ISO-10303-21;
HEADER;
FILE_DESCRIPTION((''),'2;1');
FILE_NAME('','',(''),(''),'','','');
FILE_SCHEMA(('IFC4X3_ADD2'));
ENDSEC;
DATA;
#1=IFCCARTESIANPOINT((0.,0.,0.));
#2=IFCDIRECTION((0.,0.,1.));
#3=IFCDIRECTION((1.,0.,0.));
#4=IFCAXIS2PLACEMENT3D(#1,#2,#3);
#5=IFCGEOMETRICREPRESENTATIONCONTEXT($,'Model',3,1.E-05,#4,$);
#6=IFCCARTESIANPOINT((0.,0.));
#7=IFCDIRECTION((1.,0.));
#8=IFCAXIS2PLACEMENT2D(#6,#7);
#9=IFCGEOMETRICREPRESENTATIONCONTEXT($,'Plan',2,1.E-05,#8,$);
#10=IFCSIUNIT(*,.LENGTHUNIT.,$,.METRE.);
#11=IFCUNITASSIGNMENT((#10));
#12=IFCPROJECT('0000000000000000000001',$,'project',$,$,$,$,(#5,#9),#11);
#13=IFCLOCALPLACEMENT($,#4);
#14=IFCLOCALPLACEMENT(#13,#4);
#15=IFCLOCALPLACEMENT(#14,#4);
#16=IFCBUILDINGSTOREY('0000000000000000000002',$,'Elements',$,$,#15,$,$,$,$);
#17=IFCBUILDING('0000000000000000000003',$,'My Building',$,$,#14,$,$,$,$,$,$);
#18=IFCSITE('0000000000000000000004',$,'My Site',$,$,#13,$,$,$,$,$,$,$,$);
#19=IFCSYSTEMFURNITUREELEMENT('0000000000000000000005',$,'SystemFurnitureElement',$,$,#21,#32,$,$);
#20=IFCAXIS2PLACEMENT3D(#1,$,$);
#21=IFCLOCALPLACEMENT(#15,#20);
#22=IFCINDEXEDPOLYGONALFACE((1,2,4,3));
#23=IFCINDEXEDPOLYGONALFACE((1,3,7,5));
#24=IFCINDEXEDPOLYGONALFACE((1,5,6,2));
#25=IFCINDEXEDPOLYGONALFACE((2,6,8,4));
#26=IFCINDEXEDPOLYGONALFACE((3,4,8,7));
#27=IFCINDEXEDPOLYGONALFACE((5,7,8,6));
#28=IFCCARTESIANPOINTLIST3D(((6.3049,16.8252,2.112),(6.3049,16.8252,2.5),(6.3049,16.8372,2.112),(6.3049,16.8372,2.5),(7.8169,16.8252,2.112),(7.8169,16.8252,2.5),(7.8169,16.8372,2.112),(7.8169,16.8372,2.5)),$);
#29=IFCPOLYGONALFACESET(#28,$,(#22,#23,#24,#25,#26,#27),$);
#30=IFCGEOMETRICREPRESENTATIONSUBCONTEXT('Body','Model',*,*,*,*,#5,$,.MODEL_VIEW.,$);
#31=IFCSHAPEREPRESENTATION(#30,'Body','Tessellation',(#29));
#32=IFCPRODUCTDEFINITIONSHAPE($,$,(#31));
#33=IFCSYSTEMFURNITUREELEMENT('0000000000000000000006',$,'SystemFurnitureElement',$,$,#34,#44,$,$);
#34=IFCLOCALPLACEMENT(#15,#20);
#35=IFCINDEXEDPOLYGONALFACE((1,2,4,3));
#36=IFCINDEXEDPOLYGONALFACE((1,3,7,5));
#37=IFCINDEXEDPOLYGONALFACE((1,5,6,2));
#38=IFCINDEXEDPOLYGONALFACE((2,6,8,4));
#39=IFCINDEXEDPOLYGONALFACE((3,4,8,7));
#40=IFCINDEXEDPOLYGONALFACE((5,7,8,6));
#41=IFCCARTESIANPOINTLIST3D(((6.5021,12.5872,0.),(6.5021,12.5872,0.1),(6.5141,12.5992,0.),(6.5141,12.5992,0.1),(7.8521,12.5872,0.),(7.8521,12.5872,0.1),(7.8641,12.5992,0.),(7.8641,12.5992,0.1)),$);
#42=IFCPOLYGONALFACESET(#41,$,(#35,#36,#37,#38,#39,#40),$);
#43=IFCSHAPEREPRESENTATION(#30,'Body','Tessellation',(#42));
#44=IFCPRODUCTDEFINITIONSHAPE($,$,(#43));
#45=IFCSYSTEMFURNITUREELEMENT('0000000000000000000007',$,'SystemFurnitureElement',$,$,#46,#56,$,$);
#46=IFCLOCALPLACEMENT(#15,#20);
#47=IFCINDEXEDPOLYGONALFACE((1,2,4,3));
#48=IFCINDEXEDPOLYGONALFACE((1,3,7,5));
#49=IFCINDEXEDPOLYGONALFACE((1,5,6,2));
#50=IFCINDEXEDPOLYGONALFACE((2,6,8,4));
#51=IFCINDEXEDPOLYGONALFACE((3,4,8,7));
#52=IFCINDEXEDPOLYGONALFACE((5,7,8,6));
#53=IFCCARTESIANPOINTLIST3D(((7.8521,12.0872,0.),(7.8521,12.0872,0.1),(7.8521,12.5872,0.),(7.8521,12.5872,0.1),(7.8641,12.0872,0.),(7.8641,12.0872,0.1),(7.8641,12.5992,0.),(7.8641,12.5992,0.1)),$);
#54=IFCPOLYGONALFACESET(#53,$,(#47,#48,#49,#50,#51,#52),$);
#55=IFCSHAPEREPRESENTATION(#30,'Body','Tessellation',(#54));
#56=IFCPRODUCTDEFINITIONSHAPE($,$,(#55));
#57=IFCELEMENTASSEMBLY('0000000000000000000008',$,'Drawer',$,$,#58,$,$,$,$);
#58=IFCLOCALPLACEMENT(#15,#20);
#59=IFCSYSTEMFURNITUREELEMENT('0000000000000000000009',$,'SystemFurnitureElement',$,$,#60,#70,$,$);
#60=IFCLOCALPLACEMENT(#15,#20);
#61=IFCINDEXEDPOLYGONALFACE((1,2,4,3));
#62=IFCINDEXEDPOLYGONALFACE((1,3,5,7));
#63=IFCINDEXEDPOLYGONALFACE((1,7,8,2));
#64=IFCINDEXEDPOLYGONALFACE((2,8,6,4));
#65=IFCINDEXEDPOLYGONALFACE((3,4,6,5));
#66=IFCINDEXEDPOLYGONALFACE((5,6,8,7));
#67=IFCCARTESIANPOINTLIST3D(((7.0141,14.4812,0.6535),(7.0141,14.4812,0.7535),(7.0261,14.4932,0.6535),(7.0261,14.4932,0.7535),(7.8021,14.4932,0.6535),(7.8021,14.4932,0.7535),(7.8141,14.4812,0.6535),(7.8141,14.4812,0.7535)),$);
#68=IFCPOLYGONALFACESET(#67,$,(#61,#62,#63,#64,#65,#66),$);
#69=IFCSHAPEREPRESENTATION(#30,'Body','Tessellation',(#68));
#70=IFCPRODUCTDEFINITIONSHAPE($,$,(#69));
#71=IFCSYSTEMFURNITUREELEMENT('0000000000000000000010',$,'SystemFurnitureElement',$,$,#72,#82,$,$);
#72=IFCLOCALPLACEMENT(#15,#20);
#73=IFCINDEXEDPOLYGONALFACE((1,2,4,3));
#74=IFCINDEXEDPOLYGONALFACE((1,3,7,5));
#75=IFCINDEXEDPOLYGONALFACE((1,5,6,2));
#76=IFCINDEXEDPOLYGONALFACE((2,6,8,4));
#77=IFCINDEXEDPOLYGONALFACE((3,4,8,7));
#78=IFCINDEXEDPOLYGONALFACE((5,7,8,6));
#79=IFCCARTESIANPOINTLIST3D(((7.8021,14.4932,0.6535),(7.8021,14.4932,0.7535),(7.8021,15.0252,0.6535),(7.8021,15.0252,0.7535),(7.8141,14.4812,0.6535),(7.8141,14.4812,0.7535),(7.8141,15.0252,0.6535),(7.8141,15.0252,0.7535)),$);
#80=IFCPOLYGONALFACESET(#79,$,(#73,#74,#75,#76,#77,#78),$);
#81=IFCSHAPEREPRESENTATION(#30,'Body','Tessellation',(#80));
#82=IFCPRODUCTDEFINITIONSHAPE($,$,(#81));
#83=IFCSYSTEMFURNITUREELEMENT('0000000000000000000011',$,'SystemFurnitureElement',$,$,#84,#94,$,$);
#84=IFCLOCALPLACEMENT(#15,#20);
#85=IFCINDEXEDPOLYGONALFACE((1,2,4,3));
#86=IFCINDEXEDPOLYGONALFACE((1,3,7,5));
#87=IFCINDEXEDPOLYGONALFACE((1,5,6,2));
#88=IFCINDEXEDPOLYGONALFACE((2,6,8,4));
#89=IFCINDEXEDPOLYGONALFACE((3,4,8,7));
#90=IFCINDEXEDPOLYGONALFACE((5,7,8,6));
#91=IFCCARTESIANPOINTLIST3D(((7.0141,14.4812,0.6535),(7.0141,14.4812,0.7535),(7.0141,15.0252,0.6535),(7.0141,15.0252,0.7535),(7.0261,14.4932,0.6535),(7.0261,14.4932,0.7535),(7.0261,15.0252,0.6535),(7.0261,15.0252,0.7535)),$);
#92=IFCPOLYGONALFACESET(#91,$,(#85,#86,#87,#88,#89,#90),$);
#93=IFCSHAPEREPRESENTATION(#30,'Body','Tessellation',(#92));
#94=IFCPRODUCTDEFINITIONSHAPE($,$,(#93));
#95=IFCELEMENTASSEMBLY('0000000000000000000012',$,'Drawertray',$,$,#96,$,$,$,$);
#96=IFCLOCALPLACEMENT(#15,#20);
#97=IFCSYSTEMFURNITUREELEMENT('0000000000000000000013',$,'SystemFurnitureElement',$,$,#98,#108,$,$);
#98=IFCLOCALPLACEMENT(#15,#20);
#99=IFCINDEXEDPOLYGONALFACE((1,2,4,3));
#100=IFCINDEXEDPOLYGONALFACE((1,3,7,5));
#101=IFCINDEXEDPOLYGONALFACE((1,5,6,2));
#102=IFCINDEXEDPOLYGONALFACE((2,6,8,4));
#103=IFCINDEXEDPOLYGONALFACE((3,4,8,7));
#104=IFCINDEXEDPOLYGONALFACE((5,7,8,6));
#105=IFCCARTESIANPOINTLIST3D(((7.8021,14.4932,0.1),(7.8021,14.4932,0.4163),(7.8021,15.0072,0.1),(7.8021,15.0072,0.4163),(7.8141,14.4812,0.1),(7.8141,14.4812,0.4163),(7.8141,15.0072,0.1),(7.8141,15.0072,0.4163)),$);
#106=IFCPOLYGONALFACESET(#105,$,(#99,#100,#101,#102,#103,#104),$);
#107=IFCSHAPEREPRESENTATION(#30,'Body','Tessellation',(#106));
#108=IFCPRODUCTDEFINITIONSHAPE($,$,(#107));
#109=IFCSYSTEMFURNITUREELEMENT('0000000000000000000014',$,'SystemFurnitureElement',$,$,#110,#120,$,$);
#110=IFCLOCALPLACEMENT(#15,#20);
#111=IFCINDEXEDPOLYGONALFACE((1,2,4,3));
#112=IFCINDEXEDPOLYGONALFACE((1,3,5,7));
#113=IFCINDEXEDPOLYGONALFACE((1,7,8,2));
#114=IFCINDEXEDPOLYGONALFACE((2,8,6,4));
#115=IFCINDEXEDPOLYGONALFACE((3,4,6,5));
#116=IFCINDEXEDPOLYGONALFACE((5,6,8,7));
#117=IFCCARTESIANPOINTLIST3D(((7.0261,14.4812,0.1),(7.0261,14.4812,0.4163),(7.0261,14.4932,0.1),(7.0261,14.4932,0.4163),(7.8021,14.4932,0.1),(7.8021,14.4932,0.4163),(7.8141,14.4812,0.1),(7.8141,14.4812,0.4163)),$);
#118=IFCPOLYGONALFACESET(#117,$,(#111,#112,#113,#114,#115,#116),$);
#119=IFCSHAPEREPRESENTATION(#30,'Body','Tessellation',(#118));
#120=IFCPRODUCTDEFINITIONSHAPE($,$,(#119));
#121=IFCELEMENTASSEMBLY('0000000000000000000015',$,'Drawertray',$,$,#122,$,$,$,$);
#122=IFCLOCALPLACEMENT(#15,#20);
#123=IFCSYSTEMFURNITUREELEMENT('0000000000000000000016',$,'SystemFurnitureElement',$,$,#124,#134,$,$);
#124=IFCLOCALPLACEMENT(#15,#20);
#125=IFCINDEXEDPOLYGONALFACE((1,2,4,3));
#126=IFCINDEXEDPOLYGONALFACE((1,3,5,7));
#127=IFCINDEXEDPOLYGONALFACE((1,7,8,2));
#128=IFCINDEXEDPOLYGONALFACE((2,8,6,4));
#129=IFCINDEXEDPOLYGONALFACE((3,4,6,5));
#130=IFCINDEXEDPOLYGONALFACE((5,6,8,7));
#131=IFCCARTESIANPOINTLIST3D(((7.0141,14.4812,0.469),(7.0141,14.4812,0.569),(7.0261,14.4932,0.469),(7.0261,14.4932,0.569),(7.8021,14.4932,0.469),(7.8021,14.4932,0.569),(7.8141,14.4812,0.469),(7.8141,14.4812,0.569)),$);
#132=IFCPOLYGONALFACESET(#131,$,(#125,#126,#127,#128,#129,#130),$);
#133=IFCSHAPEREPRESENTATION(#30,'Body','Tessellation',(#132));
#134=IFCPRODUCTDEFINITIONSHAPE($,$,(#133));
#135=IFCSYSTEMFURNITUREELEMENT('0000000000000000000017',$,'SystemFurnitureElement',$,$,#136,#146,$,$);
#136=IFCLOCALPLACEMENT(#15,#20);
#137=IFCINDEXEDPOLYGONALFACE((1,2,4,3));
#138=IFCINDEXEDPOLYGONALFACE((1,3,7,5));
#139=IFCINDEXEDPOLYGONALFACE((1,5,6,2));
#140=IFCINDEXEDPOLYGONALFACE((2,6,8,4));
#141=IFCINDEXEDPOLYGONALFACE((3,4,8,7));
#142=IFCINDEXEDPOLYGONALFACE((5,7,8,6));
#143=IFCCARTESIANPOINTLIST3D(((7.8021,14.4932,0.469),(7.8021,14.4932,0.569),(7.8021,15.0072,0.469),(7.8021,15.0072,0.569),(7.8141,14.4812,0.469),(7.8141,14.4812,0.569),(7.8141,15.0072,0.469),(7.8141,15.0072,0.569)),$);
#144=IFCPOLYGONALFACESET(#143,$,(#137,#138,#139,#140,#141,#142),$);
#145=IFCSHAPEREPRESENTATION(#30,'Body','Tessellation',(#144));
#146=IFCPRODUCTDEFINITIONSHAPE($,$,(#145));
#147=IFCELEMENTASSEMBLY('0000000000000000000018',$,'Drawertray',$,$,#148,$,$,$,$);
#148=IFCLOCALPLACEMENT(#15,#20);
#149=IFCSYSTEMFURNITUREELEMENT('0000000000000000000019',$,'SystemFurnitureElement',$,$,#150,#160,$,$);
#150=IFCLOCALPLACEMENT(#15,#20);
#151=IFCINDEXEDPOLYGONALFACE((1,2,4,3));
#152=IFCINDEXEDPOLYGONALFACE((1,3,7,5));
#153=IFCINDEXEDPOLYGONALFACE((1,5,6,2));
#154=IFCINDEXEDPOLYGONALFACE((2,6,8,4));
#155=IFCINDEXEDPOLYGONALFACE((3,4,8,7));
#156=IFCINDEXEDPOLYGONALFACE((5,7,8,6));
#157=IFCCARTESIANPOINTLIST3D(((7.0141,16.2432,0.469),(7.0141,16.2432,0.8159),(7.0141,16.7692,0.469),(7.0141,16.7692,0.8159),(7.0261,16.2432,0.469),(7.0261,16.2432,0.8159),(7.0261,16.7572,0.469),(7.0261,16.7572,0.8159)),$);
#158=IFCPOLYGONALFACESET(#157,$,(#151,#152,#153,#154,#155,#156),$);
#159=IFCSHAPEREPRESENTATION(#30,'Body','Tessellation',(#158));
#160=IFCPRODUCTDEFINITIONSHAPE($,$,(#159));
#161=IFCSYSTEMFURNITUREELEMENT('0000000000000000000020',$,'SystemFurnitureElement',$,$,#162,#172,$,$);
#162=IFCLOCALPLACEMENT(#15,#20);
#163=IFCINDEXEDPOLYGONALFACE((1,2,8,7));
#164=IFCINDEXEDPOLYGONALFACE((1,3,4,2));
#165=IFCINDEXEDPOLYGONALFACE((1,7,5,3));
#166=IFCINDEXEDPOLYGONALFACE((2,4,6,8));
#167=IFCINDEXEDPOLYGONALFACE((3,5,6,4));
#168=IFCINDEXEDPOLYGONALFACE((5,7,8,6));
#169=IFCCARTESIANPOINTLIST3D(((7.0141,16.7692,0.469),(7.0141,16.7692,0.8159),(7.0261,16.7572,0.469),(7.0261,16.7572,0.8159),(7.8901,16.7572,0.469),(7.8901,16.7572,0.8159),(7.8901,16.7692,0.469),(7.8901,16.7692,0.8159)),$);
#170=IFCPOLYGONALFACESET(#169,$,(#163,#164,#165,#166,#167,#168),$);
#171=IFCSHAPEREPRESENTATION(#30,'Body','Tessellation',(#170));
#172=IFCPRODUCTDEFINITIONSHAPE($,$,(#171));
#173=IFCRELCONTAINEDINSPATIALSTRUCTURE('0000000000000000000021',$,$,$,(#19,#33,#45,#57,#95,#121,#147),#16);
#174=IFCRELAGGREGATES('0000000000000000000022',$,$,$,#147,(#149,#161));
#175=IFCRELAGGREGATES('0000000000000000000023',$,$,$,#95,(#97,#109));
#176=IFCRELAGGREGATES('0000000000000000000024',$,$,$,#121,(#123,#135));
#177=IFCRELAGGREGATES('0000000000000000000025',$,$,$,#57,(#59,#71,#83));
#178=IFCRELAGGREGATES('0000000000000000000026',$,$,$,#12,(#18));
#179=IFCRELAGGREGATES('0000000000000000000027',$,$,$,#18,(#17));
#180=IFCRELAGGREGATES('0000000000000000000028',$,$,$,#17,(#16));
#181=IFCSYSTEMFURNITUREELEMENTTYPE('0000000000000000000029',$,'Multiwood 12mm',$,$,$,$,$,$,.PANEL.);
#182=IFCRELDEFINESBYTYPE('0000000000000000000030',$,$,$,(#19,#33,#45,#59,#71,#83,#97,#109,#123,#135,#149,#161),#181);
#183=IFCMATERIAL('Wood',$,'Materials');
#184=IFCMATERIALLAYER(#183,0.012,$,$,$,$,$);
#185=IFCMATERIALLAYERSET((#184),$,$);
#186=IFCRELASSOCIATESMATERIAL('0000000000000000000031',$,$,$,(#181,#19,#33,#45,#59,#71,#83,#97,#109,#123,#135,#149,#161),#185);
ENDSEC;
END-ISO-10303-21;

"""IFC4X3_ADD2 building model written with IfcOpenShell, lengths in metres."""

from ifc_helpers import new_model, si_unit, frame, origin_with_axes, origin_2d_with_axis, place, context, subcontext, project, spatial, line, indexed_curve, outline, extrude, material, layer, layer_set, layer_usage, type_object, element, aggregate, save


model = new_model("IFC4X3_ADD2")

# Units and contexts
model_context = context("Model", 3, precision=1e-05, world=origin_with_axes())
plan_context = context("Plan", 2, precision=1e-05, world=origin_2d_with_axis())
body_context = subcontext(model_context, "Body", "Model", "MODEL_VIEW")
ifc_project = project(units=[si_unit("LENGTHUNIT", "METRE")], contexts=[model_context, plan_context])

# Site, building, storey
site_placement = place(None, origin_with_axes())
site = spatial("IfcSite", under=ifc_project, at=site_placement, Name="My Site")
building_placement = place(site_placement, origin_with_axes())
building = spatial("IfcBuilding", under=site, at=building_placement, Name="My Building")
storey_placement = place(building_placement, origin_with_axes())
storey = spatial("IfcBuildingStorey", under=building, at=storey_placement, Name="Elements")

# System furniture elements
ifc_material_1 = material(Name="Wood", Category="Materials")
ifc_layer_1 = layer(ifc_material_1, 0.012)
ifc_layer_set_1 = layer_set([ifc_layer_1])
system_furniture_element_type_1 = type_object("IfcSystemFurnitureElementType", Name="Multiwood 12mm", PredefinedType="PANEL", material=ifc_layer_set_1)
ifc_layer_usage_1 = layer_usage(ifc_layer_set_1, "AXIS2", "POSITIVE", 0.0)
system_furniture_element_1_placement = place(storey_placement, frame((7.8169, 16.8372, 2.112), z_axis=(0.0, 0.0, 1.0), x_axis=(-1.0, 0.000001, 0.0)))
element("IfcSystemFurnitureElement", 1, at=system_furniture_element_1_placement, inside=storey, type_object=system_furniture_element_type_1, material=ifc_layer_usage_1, Name="SystemFurnitureElement", context=body_context, shape_type="SweptSolid", body=[
    extrude(outline(indexed_curve([(0.0, 0.0), (0.0, 0.012), (1.512, 0.012), (1.512, 0.0)], segments=[line(1, 2, 3, 4, 1)])), origin_with_axes(), (0.0, 0.0, 1.0), 0.388),
])
ifc_layer_usage_2 = layer_usage(ifc_layer_set_1, "AXIS2", "POSITIVE", 0.0)
system_furniture_element_2_placement = place(storey_placement, frame((7.8521, 12.5992, 0.0), z_axis=(0.0, 0.0, 1.0), x_axis=(-1.0, 0.0, 0.0)))
element("IfcSystemFurnitureElement", 2, at=system_furniture_element_2_placement, inside=storey, type_object=system_furniture_element_type_1, material=ifc_layer_usage_2, Name="SystemFurnitureElement", context=body_context, shape_type="SweptSolid", body=[
    extrude(outline(indexed_curve([(-0.012, 0.0), (0.0, 0.012), (1.35, 0.012), (1.338, 0.0)], segments=[line(1, 2, 3, 4, 1)])), origin_with_axes(), (0.0, 0.0, 1.0), 0.1),
])
ifc_layer_usage_3 = layer_usage(ifc_layer_set_1, "AXIS2", "POSITIVE", 0.0)
system_furniture_element_3_placement = place(storey_placement, frame((7.8521, 12.5992, 0.0), z_axis=(0.0, 0.0, 1.0), x_axis=(0.0, -1.0, 0.0)))
element("IfcSystemFurnitureElement", 3, at=system_furniture_element_3_placement, inside=storey, type_object=system_furniture_element_type_1, material=ifc_layer_usage_3, Name="SystemFurnitureElement", context=body_context, shape_type="SweptSolid", body=[
    extrude(outline(indexed_curve([(0.012, 0.0), (0.0, 0.012), (0.512, 0.012), (0.512, 0.0)], segments=[line(1, 2, 3, 4, 1)])), origin_with_axes(), (0.0, 0.0, 1.0), 0.1),
])

# Element assemblies, system furniture elements
assembly_1_placement = place(storey_placement, frame((7.8141, 15.0252, 0.6535), z_axis=(0.0, 0.0, 1.0), x_axis=(1.0, 0.0, 0.0)))
assembly_1 = element("IfcElementAssembly", 4, at=assembly_1_placement, inside=storey, Name="Drawer")
ifc_layer_usage_4 = layer_usage(ifc_layer_set_1, "AXIS2", "POSITIVE", 0.0)
system_furniture_element_4_placement = place(assembly_1_placement, frame((0.0, -0.532, 0.0), z_axis=(0.0, 0.0, 1.0), x_axis=(-1.0, 0.0, 0.0)))
system_furniture_element_4 = element("IfcSystemFurnitureElement", 5, at=system_furniture_element_4_placement, type_object=system_furniture_element_type_1, material=ifc_layer_usage_4, Name="SystemFurnitureElement", context=body_context, shape_type="SweptSolid", body=[
    extrude(outline(indexed_curve([(0.012, 0.0), (0.0, 0.012), (0.8, 0.012), (0.788, 0.0)], segments=[line(1, 2, 3, 4, 1)])), origin_with_axes(), (0.0, 0.0, 1.0), 0.1),
])
ifc_layer_usage_5 = layer_usage(ifc_layer_set_1, "AXIS2", "POSITIVE", 0.0)
system_furniture_element_5_placement = place(assembly_1_placement, frame((0.0, -0.532, 0.0), z_axis=(0.0, 0.0, 1.0), x_axis=(0.000001, 1.0, 0.0)))
system_furniture_element_5 = element("IfcSystemFurnitureElement", 6, at=system_furniture_element_5_placement, type_object=system_furniture_element_type_1, material=ifc_layer_usage_5, Name="SystemFurnitureElement", context=body_context, shape_type="SweptSolid", body=[
    extrude(outline(indexed_curve([(-0.012, 0.0), (0.0, 0.012), (0.532, 0.012), (0.532, 0.0)], segments=[line(1, 2, 3, 4, 1)])), origin_with_axes(), (0.0, 0.0, 1.0), 0.1),
])
ifc_layer_usage_6 = layer_usage(ifc_layer_set_1, "AXIS2", "POSITIVE", 0.0)
system_furniture_element_6_placement = place(assembly_1_placement, frame((-0.788, -0.532, 0.0), z_axis=(0.0, 0.0, 1.0), x_axis=(0.000001, 1.0, 0.0)))
system_furniture_element_6 = element("IfcSystemFurnitureElement", 7, at=system_furniture_element_6_placement, type_object=system_furniture_element_type_1, material=ifc_layer_usage_6, Name="SystemFurnitureElement", context=body_context, shape_type="SweptSolid", body=[
    extrude(outline(indexed_curve([(0.0, 0.0), (-0.012, 0.012), (0.532, 0.012), (0.532, 0.0)], segments=[line(1, 2, 3, 4, 1)])), origin_with_axes(), (0.0, 0.0, 1.0), 0.1),
])
assembly_2_placement = place(storey_placement, frame((7.8141, 15.0252, 0.1), z_axis=(0.0, 0.0, 1.0), x_axis=(1.0, 0.0, 0.0)))
assembly_2 = element("IfcElementAssembly", 8, at=assembly_2_placement, inside=storey, Name="Drawertray")
ifc_layer_usage_7 = layer_usage(ifc_layer_set_1, "AXIS2", "POSITIVE", 0.0)
system_furniture_element_7_placement = place(assembly_2_placement, frame((0.0, -0.532, 0.0), z_axis=(0.0, 0.0, 1.0), x_axis=(0.000001, 1.0, 0.0)))
system_furniture_element_7 = element("IfcSystemFurnitureElement", 9, at=system_furniture_element_7_placement, type_object=system_furniture_element_type_1, material=ifc_layer_usage_7, Name="SystemFurnitureElement", context=body_context, shape_type="SweptSolid", body=[
    extrude(outline(indexed_curve([(-0.012, 0.0), (0.0, 0.012), (0.514, 0.012), (0.514, 0.0)], segments=[line(1, 2, 3, 4, 1)])), origin_with_axes(), (0.0, 0.0, 1.0), 0.3163),
])
ifc_layer_usage_8 = layer_usage(ifc_layer_set_1, "AXIS2", "POSITIVE", 0.0)
system_furniture_element_8_placement = place(assembly_2_placement, frame((0.0, -0.532, 0.0), z_axis=(0.0, 0.0, 1.0), x_axis=(-1.0, 0.0, 0.0)))
system_furniture_element_8 = element("IfcSystemFurnitureElement", 10, at=system_furniture_element_8_placement, type_object=system_furniture_element_type_1, material=ifc_layer_usage_8, Name="SystemFurnitureElement", context=body_context, shape_type="SweptSolid", body=[
    extrude(outline(indexed_curve([(0.012, 0.0), (0.0, 0.012), (0.788, 0.012), (0.788, 0.0)], segments=[line(1, 2, 3, 4, 1)])), origin_with_axes(), (0.0, 0.0, 1.0), 0.3163),
])
assembly_3_placement = place(storey_placement, frame((7.8141, 15.0252, 0.469), z_axis=(0.0, 0.0, 1.0), x_axis=(1.0, 0.0, 0.0)))
assembly_3 = element("IfcElementAssembly", 11, at=assembly_3_placement, inside=storey, Name="Drawertray")
ifc_layer_usage_9 = layer_usage(ifc_layer_set_1, "AXIS2", "POSITIVE", 0.0)
system_furniture_element_9_placement = place(assembly_3_placement, frame((0.0, -0.532, 0.0), z_axis=(0.0, 0.0, 1.0), x_axis=(-1.0, 0.0, 0.0)))
system_furniture_element_9 = element("IfcSystemFurnitureElement", 12, at=system_furniture_element_9_placement, type_object=system_furniture_element_type_1, material=ifc_layer_usage_9, Name="SystemFurnitureElement", context=body_context, shape_type="SweptSolid", body=[
    extrude(outline(indexed_curve([(0.012, 0.0), (0.0, 0.012), (0.8, 0.012), (0.788, 0.0)], segments=[line(1, 2, 3, 4, 1)])), origin_with_axes(), (0.0, 0.0, 1.0), 0.1),
])
ifc_layer_usage_10 = layer_usage(ifc_layer_set_1, "AXIS2", "POSITIVE", 0.0)
system_furniture_element_10_placement = place(assembly_3_placement, frame((0.0, -0.532, 0.0), z_axis=(0.0, 0.0, 1.0), x_axis=(0.000001, 1.0, 0.0)))
system_furniture_element_10 = element("IfcSystemFurnitureElement", 13, at=system_furniture_element_10_placement, type_object=system_furniture_element_type_1, material=ifc_layer_usage_10, Name="SystemFurnitureElement", context=body_context, shape_type="SweptSolid", body=[
    extrude(outline(indexed_curve([(-0.012, 0.0), (0.0, 0.012), (0.514, 0.012), (0.514, 0.0)], segments=[line(1, 2, 3, 4, 1)])), origin_with_axes(), (0.0, 0.0, 1.0), 0.1),
])
assembly_4_placement = place(storey_placement, frame((7.0141, 16.2252, 0.469), z_axis=(0.0, 0.0, 1.0), x_axis=(-1.0, 0.0, 0.0)))
assembly_4 = element("IfcElementAssembly", 14, at=assembly_4_placement, inside=storey, Name="Drawertray")
ifc_layer_usage_11 = layer_usage(ifc_layer_set_1, "AXIS2", "POSITIVE", 0.0)
system_furniture_element_11_placement = place(assembly_4_placement, frame((0.0, -0.532, 0.0), z_axis=(0.0, 0.0, 1.0), x_axis=(0.000001, 1.0, 0.0)))
system_furniture_element_11 = element("IfcSystemFurnitureElement", 15, at=system_furniture_element_11_placement, type_object=system_furniture_element_type_1, material=ifc_layer_usage_11, Name="SystemFurnitureElement", context=body_context, shape_type="SweptSolid", body=[
    extrude(outline(indexed_curve([(-0.012, 0.0), (0.0, 0.012), (0.514, 0.012), (0.514, 0.0)], segments=[line(1, 2, 3, 4, 1)])), origin_with_axes(), (0.0, 0.0, 1.0), 0.3469),
])
ifc_layer_usage_12 = layer_usage(ifc_layer_set_1, "AXIS2", "POSITIVE", 0.0)
system_furniture_element_12_placement = place(assembly_4_placement, frame((0.0, -0.532, 0.0), z_axis=(0.0, 0.0, 1.0), x_axis=(-1.0, 0.0, 0.0)))
system_furniture_element_12 = element("IfcSystemFurnitureElement", 16, at=system_furniture_element_12_placement, type_object=system_furniture_element_type_1, material=ifc_layer_usage_12, Name="SystemFurnitureElement", context=body_context, shape_type="SweptSolid", body=[
    extrude(outline(indexed_curve([(0.012, 0.0), (0.0, 0.012), (0.876, 0.012), (0.876, 0.0)], segments=[line(1, 2, 3, 4, 1)])), origin_with_axes(), (0.0, 0.0, 1.0), 0.3469),
])

aggregate(assembly_4, [system_furniture_element_11, system_furniture_element_12])

aggregate(assembly_2, [system_furniture_element_7, system_furniture_element_8])
aggregate(assembly_3, [system_furniture_element_9, system_furniture_element_10])
aggregate(assembly_1, [system_furniture_element_4, system_furniture_element_5, system_furniture_element_6])

save(model, "model.ifc")
